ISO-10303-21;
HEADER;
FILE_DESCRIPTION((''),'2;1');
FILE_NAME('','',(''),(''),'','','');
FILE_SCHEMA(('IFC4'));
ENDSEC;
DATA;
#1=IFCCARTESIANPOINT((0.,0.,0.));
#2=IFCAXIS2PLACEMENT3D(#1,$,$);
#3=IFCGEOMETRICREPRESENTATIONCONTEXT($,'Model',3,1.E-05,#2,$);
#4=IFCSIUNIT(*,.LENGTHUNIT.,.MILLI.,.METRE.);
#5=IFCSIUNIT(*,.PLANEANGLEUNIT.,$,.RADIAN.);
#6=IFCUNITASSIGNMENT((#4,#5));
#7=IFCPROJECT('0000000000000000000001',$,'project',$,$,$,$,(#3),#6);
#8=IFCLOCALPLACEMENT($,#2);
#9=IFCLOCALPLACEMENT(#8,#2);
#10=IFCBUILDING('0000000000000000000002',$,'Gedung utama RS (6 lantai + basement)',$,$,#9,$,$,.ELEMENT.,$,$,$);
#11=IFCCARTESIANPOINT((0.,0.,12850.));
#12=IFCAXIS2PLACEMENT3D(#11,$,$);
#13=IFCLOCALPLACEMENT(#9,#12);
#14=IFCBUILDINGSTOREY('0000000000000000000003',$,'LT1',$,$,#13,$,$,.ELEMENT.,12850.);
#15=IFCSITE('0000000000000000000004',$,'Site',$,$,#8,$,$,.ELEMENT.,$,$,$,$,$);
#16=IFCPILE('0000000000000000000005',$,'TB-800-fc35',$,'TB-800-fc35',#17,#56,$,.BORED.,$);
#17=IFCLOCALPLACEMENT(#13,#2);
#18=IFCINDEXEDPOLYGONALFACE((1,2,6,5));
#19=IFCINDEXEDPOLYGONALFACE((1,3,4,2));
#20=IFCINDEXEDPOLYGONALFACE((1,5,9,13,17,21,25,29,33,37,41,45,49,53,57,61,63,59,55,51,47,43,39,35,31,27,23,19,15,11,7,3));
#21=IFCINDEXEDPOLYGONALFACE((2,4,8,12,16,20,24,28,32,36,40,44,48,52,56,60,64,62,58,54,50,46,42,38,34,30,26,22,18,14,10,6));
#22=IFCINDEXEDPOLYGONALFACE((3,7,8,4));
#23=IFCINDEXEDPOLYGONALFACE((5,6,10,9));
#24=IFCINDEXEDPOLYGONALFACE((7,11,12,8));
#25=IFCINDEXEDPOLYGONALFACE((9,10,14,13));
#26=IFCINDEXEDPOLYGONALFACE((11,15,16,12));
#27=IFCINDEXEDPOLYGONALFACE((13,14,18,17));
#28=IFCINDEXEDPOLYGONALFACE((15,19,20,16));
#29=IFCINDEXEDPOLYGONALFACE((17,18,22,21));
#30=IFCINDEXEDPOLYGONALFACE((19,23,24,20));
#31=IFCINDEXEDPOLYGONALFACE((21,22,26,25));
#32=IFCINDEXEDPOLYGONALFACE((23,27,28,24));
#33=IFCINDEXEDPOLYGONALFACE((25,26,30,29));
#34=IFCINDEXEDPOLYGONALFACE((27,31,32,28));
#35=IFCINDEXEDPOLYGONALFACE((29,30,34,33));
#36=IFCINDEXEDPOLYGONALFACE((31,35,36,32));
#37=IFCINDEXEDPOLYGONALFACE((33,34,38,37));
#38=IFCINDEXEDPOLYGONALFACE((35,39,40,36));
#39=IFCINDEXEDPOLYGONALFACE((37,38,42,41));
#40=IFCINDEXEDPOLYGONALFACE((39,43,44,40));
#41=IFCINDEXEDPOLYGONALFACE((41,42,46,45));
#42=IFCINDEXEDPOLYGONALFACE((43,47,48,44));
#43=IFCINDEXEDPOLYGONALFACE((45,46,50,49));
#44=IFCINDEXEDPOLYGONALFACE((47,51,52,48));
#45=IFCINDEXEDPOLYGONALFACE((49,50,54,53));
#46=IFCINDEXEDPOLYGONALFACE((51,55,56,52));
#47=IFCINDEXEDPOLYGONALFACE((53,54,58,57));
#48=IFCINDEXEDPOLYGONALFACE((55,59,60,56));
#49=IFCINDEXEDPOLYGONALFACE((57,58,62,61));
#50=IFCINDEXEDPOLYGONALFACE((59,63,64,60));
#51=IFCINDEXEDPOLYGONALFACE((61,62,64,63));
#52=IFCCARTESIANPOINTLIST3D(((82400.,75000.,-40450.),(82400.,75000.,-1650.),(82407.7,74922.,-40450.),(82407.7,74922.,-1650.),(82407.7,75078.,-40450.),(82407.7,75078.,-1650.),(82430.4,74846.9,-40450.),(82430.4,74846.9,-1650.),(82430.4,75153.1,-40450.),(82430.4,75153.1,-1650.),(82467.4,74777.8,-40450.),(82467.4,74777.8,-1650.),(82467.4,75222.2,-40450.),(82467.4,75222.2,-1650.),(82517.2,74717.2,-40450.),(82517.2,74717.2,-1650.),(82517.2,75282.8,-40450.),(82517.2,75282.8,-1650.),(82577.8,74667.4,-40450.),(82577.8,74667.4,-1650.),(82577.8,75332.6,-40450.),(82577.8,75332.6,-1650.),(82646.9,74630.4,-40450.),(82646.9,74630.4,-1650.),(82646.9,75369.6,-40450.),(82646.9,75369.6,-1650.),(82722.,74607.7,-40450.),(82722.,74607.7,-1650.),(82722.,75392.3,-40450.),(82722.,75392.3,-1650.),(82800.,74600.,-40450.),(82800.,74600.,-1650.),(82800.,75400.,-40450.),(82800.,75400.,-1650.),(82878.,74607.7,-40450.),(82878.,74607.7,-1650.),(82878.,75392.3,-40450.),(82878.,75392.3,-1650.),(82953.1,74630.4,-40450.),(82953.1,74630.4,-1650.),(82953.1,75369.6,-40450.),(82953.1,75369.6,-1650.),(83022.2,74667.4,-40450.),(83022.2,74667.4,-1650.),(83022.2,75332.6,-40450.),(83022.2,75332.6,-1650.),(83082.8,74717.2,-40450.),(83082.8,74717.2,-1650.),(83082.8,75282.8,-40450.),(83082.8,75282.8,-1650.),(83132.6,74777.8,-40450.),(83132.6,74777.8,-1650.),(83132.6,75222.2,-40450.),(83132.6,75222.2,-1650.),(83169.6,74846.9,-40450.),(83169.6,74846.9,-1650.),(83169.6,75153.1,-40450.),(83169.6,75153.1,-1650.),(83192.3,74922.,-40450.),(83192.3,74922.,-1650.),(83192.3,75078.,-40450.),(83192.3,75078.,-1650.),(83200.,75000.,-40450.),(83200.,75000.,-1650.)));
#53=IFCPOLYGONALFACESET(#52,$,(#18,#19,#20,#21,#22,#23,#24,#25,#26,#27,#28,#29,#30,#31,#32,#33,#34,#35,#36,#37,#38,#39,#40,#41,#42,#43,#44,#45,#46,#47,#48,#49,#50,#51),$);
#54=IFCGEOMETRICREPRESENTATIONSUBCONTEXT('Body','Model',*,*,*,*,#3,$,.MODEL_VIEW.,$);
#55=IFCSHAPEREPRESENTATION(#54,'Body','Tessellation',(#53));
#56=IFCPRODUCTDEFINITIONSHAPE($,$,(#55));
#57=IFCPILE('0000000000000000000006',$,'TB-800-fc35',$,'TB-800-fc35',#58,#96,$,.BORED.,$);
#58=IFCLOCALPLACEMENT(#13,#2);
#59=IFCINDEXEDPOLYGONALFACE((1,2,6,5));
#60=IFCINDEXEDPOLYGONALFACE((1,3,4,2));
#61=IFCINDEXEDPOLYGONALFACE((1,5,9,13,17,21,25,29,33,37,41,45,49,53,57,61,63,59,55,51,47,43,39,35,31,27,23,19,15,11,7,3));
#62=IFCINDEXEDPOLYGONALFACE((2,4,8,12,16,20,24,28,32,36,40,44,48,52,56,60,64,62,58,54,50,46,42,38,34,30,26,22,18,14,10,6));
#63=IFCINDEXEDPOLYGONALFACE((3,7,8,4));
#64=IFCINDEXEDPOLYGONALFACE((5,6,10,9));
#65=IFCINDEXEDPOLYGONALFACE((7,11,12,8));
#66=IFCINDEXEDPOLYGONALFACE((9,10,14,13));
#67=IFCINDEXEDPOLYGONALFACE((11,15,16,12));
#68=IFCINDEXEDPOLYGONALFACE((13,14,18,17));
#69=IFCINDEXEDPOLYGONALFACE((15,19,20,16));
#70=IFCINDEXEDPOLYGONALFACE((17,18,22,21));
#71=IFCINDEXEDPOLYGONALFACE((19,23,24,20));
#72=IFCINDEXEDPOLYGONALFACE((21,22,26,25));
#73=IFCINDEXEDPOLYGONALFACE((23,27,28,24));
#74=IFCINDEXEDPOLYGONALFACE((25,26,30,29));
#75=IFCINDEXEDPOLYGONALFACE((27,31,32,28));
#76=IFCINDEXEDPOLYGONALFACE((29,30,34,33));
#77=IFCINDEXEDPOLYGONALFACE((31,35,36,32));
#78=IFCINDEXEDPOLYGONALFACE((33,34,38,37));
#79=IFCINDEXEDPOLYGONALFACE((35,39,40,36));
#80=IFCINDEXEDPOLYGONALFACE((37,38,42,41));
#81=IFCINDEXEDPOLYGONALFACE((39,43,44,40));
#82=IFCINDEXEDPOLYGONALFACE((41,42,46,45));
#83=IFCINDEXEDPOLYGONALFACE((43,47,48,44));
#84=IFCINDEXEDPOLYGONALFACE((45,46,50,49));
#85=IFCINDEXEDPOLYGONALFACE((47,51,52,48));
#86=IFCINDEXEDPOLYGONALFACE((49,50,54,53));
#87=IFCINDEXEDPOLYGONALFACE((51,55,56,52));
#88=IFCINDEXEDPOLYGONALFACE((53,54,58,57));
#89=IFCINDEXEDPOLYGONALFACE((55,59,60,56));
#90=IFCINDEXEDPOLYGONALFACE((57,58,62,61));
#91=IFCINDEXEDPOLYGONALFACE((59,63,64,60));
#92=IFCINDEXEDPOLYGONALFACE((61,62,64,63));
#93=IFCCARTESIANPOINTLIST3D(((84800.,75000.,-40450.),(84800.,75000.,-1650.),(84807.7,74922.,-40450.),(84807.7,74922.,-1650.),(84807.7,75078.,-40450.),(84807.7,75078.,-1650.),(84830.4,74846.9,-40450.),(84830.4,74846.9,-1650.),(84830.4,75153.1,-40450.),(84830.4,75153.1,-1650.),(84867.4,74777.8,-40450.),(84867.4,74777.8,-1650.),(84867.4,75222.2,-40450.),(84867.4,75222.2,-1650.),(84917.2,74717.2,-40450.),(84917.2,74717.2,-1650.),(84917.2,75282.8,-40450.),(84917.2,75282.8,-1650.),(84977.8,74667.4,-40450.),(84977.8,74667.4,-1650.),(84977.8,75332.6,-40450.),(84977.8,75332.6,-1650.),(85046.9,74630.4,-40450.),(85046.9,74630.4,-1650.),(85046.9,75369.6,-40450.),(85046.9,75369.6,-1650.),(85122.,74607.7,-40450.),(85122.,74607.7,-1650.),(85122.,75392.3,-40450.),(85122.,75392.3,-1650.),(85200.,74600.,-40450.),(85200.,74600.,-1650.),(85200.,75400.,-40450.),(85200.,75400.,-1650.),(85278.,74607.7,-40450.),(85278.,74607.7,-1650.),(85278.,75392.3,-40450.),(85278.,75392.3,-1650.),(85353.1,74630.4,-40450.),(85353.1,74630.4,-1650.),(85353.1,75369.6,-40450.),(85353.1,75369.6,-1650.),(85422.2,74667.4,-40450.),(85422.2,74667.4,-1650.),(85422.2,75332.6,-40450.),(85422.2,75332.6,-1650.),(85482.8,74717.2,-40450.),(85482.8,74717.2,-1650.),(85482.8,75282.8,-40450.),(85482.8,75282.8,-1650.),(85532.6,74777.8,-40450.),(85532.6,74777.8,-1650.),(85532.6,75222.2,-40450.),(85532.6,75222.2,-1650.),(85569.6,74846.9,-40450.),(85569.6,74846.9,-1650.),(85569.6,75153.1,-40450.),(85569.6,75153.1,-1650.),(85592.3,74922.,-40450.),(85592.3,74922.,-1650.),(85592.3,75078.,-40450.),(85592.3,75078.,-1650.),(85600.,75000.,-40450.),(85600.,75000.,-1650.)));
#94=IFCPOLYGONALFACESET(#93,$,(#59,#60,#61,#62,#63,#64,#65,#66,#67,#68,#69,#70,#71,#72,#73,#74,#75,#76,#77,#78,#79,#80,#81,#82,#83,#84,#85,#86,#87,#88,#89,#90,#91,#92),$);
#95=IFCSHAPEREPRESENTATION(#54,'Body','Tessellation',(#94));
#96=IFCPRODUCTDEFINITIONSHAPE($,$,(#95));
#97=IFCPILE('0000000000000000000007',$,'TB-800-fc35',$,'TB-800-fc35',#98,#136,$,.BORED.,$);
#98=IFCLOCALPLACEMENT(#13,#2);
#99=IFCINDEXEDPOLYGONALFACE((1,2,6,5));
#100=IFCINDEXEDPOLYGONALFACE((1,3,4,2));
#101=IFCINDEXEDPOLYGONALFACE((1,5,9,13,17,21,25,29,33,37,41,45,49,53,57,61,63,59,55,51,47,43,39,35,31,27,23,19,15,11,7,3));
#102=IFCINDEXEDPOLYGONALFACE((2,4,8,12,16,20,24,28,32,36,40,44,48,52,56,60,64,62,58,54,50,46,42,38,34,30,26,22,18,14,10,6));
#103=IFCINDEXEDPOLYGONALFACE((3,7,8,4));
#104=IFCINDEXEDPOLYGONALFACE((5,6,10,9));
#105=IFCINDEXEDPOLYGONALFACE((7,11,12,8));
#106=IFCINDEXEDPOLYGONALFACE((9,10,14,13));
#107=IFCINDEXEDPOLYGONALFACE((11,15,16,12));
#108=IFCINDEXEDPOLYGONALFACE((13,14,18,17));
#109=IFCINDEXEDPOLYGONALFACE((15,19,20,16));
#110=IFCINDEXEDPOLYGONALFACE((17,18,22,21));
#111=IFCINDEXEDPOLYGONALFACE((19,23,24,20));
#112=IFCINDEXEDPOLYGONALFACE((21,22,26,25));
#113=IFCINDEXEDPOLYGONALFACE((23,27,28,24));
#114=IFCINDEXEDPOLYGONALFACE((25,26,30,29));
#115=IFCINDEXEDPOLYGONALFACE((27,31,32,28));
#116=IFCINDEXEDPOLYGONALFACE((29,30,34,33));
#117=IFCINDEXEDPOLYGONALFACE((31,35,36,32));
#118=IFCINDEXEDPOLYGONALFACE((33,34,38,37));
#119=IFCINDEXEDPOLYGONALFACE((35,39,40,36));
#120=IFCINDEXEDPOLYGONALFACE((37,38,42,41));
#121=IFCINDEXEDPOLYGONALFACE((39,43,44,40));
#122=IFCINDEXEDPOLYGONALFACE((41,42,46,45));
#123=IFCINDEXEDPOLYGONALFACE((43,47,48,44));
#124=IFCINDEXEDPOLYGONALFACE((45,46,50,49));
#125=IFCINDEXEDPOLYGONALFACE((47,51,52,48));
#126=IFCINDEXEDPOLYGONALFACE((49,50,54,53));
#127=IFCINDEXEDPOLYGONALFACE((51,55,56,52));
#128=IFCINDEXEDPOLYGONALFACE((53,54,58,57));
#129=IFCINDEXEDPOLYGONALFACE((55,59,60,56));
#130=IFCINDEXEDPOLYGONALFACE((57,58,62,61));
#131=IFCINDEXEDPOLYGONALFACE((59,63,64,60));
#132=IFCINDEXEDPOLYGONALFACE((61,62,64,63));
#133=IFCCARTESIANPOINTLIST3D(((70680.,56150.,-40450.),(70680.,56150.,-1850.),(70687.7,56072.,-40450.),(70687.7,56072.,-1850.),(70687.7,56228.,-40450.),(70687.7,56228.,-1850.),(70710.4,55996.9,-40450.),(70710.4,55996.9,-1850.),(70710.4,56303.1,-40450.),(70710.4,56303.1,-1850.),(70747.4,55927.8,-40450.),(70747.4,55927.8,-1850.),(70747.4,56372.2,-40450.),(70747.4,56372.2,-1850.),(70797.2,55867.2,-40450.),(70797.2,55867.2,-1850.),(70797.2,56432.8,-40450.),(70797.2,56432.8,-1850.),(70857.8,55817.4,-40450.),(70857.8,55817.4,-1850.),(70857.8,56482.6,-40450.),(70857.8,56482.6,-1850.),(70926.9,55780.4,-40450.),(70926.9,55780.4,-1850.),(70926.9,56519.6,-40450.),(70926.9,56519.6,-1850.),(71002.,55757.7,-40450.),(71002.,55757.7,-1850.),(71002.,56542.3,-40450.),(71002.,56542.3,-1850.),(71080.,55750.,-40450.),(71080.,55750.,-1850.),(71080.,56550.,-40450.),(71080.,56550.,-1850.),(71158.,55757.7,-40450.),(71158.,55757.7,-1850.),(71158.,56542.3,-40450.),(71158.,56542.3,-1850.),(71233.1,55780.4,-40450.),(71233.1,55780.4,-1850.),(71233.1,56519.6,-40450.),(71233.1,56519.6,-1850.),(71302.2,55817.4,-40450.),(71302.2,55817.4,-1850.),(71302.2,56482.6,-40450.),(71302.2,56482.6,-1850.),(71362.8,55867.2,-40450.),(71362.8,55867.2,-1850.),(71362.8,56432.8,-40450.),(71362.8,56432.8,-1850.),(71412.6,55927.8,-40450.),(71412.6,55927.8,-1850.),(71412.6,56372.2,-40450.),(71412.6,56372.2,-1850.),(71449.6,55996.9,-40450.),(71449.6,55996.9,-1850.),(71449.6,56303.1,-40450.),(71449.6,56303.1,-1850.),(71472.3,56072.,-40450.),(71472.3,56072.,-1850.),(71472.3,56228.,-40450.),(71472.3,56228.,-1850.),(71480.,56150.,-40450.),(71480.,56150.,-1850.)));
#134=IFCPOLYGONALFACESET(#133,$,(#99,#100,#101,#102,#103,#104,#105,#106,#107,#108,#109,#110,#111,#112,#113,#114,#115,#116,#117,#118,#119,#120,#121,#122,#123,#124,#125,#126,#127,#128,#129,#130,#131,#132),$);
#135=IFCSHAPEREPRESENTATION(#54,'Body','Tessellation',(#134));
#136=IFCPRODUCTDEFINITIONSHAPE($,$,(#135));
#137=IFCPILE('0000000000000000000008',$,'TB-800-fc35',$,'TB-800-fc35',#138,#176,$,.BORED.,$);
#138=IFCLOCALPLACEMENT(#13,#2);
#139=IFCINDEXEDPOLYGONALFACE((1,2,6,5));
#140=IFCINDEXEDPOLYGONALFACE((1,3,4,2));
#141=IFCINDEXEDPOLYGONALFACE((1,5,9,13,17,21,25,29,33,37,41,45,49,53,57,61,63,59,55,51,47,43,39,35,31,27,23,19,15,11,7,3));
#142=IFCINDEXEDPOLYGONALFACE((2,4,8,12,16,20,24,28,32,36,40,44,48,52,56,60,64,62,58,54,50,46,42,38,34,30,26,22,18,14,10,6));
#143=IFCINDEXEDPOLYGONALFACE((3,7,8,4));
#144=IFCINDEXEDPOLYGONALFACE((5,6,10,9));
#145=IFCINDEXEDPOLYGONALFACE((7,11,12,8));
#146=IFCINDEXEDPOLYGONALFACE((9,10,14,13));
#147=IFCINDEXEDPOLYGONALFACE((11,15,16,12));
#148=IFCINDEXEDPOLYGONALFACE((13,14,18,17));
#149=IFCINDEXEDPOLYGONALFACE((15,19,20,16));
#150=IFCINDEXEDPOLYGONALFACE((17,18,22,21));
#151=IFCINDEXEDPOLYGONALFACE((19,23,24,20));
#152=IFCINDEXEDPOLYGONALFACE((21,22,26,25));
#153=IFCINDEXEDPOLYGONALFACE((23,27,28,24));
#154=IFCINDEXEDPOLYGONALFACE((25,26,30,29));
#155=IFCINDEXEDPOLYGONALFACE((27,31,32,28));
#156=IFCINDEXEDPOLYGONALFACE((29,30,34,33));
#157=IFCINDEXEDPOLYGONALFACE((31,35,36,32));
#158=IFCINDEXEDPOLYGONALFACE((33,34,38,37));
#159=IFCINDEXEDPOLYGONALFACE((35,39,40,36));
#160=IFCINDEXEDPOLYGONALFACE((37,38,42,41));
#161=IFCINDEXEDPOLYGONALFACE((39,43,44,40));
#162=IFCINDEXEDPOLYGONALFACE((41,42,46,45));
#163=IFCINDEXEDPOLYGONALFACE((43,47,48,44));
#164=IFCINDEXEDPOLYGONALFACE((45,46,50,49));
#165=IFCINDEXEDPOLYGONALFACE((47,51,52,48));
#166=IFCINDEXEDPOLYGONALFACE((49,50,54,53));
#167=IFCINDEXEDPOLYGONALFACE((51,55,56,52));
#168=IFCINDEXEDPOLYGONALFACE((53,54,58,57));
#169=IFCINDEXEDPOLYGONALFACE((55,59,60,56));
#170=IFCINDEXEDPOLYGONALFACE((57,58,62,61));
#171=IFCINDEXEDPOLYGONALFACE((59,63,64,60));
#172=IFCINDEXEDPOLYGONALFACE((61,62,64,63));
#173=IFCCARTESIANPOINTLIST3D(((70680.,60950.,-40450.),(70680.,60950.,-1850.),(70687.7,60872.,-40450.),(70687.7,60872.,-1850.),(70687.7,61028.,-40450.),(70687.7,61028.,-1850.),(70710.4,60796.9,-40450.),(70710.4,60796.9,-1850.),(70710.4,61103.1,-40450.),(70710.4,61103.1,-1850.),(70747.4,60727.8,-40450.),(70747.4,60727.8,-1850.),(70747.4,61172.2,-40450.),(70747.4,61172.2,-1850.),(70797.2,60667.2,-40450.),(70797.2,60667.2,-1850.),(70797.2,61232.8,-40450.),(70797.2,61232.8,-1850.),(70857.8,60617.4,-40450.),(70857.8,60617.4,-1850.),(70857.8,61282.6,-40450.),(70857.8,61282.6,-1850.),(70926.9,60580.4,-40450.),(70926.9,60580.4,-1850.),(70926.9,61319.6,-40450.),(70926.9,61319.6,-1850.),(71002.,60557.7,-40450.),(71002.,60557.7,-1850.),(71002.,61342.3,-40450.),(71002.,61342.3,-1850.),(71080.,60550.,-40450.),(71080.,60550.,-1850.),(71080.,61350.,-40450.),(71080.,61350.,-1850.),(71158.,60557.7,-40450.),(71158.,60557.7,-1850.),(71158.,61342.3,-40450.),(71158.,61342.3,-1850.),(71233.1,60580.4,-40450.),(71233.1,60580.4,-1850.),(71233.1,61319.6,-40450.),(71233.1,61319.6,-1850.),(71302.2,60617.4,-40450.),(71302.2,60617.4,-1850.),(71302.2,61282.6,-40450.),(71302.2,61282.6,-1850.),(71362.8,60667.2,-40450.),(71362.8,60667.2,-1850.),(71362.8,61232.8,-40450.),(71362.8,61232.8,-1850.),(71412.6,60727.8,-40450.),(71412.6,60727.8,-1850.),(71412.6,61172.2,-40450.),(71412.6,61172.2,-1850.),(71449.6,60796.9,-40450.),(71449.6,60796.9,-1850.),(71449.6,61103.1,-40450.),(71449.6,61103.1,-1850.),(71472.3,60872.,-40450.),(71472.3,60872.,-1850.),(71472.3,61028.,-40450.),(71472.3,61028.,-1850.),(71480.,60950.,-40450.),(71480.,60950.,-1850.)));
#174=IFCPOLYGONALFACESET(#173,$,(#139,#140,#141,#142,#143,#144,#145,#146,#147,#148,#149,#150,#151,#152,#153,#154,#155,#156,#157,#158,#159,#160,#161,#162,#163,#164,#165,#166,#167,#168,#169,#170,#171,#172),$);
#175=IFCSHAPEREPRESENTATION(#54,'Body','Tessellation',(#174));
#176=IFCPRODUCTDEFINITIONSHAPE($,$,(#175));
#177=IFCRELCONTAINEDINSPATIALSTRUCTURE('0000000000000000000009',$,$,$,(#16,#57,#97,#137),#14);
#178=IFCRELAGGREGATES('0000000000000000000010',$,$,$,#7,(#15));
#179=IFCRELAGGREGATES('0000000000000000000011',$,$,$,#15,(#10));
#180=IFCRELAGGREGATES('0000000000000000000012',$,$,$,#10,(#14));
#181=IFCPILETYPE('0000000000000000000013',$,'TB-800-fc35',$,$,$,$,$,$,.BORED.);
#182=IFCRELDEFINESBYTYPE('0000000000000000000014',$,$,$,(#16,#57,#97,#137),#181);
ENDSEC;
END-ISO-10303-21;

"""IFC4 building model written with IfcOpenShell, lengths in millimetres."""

from ifc_helpers import new_model, si_unit, frame, origin, origin_2d, place, context, subcontext, project, spatial, circle, extrude, material_profile, profile_set, profile_usage, type_object, element, save


model = new_model("IFC4")

# Units and contexts
model_context = context("Model", 3, precision=1e-05, world=origin())
body_context = subcontext(model_context, "Body", "Model", "MODEL_VIEW")
ifc_project = project(units=[si_unit("LENGTHUNIT", "METRE", prefix="MILLI"), si_unit("PLANEANGLEUNIT", "RADIAN")], contexts=[model_context])

# Site, building, storey
site_placement = place(None, origin())
site = spatial("IfcSite", under=ifc_project, at=site_placement, Name="Site", CompositionType="ELEMENT")
building_placement = place(site_placement, origin())
building = spatial("IfcBuilding", under=site, at=building_placement, Name="Gedung utama RS (6 lantai + basement)", CompositionType="ELEMENT")
storey_placement = place(building_placement, frame((0.0, 0.0, 12850.0)))
storey = spatial("IfcBuildingStorey", under=building, at=storey_placement, Name="LT1", CompositionType="ELEMENT", Elevation=12850.0)

# Piles
ifc_material_profile_1 = material_profile(None, circle(Radius=400.0, at=origin_2d()), Name="TB-800-fc35")
ifc_profile_set_1 = profile_set([ifc_material_profile_1], Name="TB-800-fc35")
ifc_profile_usage_1 = profile_usage(ifc_profile_set_1, cardinal=5)
pile_type = type_object("IfcPileType", Name="TB-800-fc35", PredefinedType="BORED")
for number, where, z_axis, x_axis, name in (
    (1, (82800.0, 75000.0, -40450.0), (0.0, 0.0, 1.0), (1.0, 0.0, 0.0), "TB-800-fc35"),
    (2, (85200.0, 75000.0, -40450.0), (0.0, 0.0, 1.0), (1.0, 0.0, 0.0), "TB-800-fc35"),
):
    element("IfcPile", number, at=place(storey_placement, frame(where, z_axis=z_axis, x_axis=x_axis)), inside=storey, type_object=pile_type, material=ifc_profile_usage_1, Name=name, ObjectType="TB-800-fc35", PredefinedType="BORED", context=body_context, shape_type="SweptSolid", body=[
        extrude(circle(Radius=400.0, at=origin_2d()), origin(), (0.0, 0.0, 1.0), 38800.0),
    ])
for number, where, z_axis, x_axis, name in (
    (3, (71080.0, 56150.0, -40450.0), (0.0, 0.0, 1.0), (1.0, 0.0, 0.0), "TB-800-fc35"),
    (4, (71080.0, 60950.0, -40450.0), (0.0, 0.0, 1.0), (1.0, 0.0, 0.0), "TB-800-fc35"),
):
    element("IfcPile", number, at=place(storey_placement, frame(where, z_axis=z_axis, x_axis=x_axis)), inside=storey, type_object=pile_type, material=ifc_profile_usage_1, Name=name, ObjectType="TB-800-fc35", PredefinedType="BORED", context=body_context, shape_type="SweptSolid", body=[
        extrude(circle(Radius=400.0, at=origin_2d()), origin(), (0.0, 0.0, 1.0), 38600.0),
    ])

save(model, "model.ifc")
